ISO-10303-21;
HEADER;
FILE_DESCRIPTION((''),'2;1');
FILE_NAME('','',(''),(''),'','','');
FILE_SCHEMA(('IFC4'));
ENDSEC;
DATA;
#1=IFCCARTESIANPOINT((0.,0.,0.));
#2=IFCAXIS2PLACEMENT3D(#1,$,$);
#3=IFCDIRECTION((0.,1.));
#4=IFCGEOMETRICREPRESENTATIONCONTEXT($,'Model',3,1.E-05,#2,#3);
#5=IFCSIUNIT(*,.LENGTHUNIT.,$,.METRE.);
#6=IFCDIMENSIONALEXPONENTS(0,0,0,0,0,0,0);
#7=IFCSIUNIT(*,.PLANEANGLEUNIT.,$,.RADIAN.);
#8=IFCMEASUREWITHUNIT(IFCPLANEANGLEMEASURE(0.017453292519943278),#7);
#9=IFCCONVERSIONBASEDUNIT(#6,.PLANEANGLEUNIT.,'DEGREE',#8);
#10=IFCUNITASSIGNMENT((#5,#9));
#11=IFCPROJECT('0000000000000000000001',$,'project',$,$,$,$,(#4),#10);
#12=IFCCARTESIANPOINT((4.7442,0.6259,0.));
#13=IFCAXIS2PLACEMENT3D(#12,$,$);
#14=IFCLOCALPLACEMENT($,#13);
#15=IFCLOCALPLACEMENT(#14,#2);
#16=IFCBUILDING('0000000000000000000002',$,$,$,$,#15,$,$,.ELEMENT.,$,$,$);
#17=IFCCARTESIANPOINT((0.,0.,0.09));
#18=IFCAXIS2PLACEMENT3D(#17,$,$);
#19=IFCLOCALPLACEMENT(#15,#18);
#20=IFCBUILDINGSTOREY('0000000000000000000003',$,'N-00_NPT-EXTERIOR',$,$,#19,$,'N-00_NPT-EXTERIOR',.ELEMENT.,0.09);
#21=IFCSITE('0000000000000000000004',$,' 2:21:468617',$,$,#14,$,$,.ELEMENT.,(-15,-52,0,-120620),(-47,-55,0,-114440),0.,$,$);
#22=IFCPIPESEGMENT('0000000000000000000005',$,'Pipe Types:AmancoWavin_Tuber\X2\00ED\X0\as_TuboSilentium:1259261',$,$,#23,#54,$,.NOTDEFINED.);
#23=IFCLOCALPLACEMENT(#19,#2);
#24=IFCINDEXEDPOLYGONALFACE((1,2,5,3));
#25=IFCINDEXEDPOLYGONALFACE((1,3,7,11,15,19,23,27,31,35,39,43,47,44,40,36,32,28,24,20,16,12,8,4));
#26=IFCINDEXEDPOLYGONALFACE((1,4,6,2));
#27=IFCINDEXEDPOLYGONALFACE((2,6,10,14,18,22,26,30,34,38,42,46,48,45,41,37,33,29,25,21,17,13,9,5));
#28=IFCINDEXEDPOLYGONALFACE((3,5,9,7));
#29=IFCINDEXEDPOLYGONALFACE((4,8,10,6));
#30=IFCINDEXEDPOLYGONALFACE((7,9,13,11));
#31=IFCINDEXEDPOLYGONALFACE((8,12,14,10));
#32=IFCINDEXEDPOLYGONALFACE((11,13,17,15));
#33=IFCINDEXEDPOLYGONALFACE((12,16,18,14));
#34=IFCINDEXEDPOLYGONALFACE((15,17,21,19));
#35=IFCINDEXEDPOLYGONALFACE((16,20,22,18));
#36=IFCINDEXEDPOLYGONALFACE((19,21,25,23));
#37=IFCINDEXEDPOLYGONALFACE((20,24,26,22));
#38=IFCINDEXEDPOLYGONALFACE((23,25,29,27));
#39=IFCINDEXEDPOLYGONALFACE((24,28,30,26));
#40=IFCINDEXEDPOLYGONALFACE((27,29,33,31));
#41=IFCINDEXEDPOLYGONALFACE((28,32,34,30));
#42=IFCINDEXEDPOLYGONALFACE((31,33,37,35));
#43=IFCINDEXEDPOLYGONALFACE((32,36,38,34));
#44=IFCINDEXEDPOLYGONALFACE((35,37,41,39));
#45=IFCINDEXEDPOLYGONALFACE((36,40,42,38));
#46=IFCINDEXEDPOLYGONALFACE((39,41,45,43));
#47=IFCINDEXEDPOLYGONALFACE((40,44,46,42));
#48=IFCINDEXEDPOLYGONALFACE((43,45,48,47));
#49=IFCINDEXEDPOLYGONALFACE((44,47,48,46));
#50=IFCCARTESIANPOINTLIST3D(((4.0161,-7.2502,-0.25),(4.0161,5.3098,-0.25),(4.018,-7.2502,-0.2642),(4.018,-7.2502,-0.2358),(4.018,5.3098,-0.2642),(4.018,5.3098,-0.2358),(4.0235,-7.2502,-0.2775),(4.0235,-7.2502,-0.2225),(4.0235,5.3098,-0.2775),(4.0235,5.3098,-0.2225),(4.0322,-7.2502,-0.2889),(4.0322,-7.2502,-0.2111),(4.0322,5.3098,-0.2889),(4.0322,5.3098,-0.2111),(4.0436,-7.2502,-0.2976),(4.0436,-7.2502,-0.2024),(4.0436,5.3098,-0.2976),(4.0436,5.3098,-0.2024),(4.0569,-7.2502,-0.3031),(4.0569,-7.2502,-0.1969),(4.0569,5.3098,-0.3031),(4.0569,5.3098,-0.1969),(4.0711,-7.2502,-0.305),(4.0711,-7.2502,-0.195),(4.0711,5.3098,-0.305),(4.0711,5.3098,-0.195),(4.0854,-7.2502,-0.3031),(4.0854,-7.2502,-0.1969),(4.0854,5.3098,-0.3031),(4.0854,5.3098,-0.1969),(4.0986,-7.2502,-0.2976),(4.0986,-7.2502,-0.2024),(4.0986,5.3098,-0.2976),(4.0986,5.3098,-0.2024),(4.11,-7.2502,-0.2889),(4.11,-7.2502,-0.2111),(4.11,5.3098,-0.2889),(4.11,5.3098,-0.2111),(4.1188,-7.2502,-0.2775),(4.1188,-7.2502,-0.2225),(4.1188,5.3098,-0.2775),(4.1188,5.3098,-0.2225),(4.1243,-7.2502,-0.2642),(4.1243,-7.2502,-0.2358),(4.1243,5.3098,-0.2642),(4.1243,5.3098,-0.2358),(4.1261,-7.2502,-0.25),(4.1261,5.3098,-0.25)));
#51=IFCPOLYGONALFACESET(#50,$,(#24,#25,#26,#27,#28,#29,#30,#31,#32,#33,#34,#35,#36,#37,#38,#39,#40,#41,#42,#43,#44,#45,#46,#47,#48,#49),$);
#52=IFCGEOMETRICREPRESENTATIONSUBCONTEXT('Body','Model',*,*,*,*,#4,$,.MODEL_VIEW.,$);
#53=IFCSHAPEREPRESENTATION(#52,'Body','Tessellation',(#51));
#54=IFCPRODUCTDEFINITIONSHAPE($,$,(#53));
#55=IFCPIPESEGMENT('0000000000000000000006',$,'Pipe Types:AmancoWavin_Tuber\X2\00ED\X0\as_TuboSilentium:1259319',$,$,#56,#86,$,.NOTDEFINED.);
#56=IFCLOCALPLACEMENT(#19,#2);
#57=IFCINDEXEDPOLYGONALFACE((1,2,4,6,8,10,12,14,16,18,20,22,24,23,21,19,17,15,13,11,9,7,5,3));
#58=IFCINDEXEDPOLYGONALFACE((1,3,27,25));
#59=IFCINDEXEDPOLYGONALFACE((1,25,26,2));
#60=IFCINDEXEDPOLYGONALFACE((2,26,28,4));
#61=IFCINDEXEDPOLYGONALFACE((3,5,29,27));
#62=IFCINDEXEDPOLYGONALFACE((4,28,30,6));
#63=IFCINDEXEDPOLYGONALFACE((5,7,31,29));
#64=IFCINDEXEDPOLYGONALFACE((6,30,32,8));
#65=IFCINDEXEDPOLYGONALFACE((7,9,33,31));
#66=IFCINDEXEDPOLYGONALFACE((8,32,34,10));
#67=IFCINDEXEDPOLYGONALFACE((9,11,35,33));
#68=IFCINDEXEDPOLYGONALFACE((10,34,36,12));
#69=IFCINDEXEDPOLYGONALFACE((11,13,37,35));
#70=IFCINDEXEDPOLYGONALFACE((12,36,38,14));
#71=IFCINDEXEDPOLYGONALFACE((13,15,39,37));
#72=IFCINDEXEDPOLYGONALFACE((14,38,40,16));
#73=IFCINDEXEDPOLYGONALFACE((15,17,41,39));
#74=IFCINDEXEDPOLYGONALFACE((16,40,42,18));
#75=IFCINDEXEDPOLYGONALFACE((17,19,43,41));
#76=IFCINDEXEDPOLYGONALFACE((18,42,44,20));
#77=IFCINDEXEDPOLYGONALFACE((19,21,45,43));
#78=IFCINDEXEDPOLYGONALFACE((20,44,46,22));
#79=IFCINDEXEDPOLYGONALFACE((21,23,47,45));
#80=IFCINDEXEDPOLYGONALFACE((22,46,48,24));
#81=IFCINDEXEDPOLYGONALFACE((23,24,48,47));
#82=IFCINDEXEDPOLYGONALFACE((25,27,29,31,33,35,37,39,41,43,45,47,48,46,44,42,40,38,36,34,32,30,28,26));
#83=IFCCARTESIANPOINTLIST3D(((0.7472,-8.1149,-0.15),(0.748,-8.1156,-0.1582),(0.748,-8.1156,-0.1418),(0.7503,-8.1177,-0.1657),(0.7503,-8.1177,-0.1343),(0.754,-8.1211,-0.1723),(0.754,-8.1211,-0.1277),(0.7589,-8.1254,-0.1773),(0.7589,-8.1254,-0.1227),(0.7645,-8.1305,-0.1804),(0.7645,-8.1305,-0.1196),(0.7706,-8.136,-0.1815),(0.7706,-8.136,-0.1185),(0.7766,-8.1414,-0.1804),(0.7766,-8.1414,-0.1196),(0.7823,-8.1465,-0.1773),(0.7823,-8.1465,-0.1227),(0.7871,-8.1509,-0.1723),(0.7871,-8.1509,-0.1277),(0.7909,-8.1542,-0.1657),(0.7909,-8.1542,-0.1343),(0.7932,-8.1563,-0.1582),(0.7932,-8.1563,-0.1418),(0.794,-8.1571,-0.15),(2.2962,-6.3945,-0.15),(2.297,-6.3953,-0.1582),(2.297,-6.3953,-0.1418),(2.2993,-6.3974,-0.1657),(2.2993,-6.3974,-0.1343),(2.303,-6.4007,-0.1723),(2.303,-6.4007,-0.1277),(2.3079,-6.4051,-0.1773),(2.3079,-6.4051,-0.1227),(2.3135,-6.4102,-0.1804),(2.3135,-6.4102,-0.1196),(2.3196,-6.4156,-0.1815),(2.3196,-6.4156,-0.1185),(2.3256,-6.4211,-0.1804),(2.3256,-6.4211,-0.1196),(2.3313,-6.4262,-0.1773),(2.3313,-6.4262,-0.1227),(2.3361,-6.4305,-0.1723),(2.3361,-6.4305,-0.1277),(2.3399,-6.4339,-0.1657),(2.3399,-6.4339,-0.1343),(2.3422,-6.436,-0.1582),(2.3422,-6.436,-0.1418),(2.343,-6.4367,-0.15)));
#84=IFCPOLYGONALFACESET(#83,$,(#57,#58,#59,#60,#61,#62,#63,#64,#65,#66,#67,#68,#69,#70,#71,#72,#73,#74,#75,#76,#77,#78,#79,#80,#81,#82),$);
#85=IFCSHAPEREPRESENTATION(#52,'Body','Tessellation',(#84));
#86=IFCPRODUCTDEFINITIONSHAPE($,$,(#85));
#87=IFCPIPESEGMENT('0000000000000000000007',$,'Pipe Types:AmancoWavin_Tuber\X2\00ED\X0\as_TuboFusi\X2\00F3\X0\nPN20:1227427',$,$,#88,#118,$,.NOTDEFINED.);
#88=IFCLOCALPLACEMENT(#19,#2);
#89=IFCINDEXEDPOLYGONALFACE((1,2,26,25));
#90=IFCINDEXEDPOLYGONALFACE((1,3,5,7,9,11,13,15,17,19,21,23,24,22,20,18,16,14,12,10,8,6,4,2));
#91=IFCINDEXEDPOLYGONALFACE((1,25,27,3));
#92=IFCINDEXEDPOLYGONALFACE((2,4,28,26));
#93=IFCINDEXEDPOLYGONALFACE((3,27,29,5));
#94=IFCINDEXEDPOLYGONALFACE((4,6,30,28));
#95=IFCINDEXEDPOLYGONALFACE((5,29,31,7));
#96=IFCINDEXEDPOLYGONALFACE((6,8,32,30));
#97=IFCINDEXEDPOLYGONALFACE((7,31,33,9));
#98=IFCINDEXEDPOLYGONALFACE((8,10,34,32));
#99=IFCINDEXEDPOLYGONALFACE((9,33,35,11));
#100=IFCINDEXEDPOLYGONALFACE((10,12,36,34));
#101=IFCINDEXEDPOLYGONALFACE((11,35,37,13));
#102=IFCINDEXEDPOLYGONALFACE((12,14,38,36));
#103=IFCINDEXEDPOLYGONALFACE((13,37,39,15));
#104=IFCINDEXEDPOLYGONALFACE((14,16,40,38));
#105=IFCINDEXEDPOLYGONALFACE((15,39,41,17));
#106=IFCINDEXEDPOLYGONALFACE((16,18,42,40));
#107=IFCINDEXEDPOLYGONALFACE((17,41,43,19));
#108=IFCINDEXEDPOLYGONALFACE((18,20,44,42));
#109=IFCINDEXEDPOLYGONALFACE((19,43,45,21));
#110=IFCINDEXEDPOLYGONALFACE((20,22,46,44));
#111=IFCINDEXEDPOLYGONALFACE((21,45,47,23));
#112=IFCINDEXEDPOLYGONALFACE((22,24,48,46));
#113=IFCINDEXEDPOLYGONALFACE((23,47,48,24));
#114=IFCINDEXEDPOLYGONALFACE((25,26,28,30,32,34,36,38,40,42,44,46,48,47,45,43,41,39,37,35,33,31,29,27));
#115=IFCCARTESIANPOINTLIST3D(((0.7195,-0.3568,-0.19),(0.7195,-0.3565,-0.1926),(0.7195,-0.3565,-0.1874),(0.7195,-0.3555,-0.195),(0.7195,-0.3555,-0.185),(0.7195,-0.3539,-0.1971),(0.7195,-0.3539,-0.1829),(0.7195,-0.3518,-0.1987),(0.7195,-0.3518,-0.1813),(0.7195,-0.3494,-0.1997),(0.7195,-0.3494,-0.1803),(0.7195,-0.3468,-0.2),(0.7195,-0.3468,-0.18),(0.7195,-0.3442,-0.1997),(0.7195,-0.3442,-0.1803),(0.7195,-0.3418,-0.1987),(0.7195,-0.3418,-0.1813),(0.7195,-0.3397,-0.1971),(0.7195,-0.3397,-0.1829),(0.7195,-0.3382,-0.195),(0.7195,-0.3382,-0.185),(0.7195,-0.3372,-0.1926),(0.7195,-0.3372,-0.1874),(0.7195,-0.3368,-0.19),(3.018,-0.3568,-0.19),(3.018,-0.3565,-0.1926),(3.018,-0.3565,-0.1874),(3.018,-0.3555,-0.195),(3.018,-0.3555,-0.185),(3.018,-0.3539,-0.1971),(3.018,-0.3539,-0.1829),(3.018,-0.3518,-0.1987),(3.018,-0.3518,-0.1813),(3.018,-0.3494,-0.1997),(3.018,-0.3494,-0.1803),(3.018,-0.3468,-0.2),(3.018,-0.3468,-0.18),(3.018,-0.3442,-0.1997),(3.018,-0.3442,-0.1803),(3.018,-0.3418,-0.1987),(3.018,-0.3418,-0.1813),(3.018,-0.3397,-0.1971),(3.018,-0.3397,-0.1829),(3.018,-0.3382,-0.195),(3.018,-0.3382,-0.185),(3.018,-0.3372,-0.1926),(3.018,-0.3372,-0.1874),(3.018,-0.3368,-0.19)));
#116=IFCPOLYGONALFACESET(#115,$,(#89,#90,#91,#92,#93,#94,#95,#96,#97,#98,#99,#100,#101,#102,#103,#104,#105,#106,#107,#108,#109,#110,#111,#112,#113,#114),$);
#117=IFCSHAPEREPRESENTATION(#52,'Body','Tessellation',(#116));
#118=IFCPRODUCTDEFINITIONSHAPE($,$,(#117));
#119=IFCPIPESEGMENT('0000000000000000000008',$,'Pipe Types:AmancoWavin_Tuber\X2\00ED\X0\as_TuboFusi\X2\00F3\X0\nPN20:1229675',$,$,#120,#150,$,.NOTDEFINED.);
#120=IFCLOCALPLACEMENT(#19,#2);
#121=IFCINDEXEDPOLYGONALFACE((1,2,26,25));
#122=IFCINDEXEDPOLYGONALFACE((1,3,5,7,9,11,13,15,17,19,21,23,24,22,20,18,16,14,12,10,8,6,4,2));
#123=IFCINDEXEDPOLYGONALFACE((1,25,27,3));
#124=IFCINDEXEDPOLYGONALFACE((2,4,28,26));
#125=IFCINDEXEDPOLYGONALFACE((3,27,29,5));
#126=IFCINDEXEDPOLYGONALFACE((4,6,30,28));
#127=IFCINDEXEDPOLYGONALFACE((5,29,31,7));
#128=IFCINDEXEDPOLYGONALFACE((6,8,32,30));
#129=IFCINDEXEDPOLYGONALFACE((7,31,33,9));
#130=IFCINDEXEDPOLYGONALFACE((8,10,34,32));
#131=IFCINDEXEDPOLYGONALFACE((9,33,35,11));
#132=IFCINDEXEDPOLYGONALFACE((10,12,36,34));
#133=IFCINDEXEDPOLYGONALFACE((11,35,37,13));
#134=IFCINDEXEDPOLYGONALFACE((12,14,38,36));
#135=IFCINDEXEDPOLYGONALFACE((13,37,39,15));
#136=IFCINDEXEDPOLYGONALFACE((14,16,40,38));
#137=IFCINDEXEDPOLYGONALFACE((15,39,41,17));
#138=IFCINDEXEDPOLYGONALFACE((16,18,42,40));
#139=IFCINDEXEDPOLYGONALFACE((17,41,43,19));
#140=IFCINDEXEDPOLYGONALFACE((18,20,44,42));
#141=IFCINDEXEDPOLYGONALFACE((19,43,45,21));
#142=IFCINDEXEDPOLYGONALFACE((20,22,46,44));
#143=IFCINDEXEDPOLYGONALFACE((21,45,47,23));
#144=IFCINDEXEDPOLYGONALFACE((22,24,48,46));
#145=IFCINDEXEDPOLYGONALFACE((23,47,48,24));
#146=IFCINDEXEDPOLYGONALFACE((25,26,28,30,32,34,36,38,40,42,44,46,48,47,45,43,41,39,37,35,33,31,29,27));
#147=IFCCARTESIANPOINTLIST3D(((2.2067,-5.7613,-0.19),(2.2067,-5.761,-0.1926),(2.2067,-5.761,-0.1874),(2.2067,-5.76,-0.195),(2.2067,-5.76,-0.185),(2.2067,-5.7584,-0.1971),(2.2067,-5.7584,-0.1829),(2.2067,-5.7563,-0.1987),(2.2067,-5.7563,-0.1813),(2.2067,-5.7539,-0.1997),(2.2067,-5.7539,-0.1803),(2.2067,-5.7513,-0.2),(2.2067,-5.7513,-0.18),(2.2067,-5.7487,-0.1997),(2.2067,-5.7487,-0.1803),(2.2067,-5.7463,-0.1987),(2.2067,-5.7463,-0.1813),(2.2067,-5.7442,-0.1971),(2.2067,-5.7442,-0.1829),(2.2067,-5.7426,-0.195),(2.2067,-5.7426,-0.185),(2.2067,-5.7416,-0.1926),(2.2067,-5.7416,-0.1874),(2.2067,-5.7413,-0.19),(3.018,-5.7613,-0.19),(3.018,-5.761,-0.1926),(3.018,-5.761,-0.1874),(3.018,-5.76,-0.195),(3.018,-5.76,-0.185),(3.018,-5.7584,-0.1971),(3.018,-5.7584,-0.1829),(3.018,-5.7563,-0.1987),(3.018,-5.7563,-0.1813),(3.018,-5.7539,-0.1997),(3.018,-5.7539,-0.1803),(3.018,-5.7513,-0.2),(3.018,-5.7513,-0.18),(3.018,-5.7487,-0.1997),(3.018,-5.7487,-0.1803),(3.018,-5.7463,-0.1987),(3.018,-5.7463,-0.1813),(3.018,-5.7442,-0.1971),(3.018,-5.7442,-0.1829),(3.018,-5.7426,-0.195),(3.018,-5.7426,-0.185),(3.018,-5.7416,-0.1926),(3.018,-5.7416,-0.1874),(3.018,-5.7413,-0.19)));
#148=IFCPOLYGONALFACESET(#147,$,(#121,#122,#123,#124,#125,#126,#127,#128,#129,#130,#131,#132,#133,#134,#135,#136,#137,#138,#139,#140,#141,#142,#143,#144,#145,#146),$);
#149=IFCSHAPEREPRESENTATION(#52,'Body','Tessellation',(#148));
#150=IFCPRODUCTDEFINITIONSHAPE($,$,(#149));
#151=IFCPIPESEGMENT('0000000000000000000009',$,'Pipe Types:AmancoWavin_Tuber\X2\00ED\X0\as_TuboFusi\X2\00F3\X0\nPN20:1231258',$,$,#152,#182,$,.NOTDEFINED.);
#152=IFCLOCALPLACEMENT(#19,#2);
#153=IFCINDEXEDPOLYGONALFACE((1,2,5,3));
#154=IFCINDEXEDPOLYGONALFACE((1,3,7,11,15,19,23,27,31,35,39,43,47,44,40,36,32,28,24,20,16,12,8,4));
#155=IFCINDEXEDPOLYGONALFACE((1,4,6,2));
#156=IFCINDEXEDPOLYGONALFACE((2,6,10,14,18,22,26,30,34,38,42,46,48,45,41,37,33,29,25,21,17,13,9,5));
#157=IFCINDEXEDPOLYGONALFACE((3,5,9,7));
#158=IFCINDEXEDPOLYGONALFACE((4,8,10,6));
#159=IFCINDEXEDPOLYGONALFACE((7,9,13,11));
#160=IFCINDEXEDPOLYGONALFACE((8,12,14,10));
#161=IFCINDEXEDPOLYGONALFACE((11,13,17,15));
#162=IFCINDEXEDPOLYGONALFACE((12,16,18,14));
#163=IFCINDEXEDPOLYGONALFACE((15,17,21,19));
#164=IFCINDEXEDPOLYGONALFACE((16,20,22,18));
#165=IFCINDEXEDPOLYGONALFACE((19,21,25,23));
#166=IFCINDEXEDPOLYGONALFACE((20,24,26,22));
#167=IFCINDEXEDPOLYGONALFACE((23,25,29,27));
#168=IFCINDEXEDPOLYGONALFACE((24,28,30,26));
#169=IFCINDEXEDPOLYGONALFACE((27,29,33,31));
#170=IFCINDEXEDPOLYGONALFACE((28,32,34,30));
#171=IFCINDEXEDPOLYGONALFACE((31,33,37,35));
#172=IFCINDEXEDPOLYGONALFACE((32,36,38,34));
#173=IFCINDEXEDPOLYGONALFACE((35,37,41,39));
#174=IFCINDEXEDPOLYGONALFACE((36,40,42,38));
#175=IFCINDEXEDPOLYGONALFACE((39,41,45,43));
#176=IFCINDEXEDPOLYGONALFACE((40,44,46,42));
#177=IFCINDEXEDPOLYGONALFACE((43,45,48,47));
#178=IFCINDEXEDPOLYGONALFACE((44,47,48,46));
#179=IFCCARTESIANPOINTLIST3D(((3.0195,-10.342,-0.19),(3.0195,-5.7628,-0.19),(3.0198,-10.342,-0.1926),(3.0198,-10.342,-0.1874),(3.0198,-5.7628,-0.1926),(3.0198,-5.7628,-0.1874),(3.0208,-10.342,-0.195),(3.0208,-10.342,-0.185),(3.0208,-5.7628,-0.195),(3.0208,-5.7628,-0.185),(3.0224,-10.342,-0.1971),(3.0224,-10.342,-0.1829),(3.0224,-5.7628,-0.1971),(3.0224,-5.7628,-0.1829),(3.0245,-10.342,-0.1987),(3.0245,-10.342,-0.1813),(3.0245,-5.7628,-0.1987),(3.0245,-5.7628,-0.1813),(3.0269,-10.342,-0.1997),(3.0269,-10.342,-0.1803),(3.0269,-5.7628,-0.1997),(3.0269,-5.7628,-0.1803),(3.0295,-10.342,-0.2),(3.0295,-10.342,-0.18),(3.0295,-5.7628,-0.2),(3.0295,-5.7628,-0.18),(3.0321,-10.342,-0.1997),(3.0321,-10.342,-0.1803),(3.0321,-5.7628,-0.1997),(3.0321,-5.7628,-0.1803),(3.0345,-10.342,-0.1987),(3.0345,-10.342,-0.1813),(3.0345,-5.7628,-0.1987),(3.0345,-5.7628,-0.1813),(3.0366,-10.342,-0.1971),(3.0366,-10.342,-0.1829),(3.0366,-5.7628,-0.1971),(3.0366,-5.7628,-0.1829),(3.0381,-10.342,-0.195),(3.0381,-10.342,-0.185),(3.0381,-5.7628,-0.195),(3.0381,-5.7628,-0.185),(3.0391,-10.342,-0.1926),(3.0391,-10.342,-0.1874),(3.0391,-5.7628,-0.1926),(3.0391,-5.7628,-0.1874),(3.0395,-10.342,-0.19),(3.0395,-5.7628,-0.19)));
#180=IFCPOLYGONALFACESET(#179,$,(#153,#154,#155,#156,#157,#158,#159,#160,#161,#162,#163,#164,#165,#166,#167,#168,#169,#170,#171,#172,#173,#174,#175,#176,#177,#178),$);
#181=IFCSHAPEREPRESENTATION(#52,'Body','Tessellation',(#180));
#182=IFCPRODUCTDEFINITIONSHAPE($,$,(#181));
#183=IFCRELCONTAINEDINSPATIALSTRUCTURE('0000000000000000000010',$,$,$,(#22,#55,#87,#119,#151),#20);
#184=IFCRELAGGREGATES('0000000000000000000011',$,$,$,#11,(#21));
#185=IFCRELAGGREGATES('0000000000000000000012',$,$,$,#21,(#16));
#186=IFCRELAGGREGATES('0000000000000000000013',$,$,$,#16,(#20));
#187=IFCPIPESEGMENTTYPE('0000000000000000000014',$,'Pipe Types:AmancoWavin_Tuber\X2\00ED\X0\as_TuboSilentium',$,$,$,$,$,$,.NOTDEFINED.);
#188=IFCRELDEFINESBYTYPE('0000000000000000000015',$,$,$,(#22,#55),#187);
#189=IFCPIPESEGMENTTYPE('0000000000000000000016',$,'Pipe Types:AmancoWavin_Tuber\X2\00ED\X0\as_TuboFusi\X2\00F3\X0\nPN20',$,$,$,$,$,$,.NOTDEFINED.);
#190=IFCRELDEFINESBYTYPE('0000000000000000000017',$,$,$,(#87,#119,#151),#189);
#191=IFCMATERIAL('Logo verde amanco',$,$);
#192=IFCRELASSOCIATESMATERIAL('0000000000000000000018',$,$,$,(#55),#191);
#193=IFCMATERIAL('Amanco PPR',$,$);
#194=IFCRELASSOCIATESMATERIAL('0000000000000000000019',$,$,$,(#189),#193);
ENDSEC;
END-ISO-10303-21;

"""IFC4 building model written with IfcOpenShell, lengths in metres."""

from ifc_helpers import new_model, entity, si_unit, converted_unit, direction, frame, origin, place, context, subcontext, project, spatial, arc, indexed_curve, outline, extrude, material, type_object, element, save


model = new_model("IFC4")

# Units and contexts
model_context = context("Model", 3, precision=1e-05, world=origin(), true_north=direction((0.0, 1.0)))
body_context = subcontext(model_context, "Body", "Model", "MODEL_VIEW")
ifc_project = project(units=[si_unit("LENGTHUNIT", "METRE"), converted_unit("PLANEANGLEUNIT", "DEGREE", entity("IfcPlaneAngleMeasure", 0.017453292519943278), si_unit("PLANEANGLEUNIT", "RADIAN"), dimensions=[0, 0, 0, 0, 0, 0, 0])], contexts=[model_context])

# Site, building, storey
site_placement = place(None, frame((4.7442, 0.6259, 0.0)))
site = spatial("IfcSite", under=ifc_project, at=site_placement, Name=" 2:21:468617", CompositionType="ELEMENT", RefLatitude=(-15, -52, 0, -120620), RefLongitude=(-47, -55, 0, -114440), RefElevation=0.0)
building_placement = place(site_placement, origin())
building = spatial("IfcBuilding", under=site, at=building_placement, CompositionType="ELEMENT")
storey_placement = place(building_placement, frame((0.0, 0.0, 0.09)))
storey = spatial("IfcBuildingStorey", under=building, at=storey_placement, Name="N-00_NPT-EXTERIOR", LongName="N-00_NPT-EXTERIOR", CompositionType="ELEMENT", Elevation=0.09)

# Pipe segments
pipe_segment_type_1 = type_object("IfcPipeSegmentType", Name="Pipe Types:AmancoWavin_Tuberías_TuboSilentium", PredefinedType="NOTDEFINED")
pipe_segment_1_placement = place(storey_placement, origin())
element("IfcPipeSegment", 1, at=pipe_segment_1_placement, inside=storey, type_object=pipe_segment_type_1, Name="Pipe Types:AmancoWavin_Tuberías_TuboSilentium:1259261", PredefinedType="NOTDEFINED", context=body_context, shape_type="SweptSolid", body=[
    extrude(outline(indexed_curve([(0.055, 0.0), (0.0389, 0.0389), (0.0, 0.055), (-0.0389, 0.0389), (-0.055, 0.0), (-0.0389, -0.0389), (0.0, -0.055), (0.0389, -0.0389)], segments=[arc(1, 2, 3), arc(3, 4, 5), arc(5, 6, 7), arc(7, 8, 1)], self_intersect=False)), frame((4.0711, -7.2502, -0.25), z_axis=(0.0, 1.0, 0.0), x_axis=(-1.0, 0.0, 0.0)), (0.0, 0.0, 1.0), 12.56),
])
ifc_material_1 = material(Name="Logo verde amanco")
pipe_segment_2_placement = place(storey_placement, origin())
element("IfcPipeSegment", 2, at=pipe_segment_2_placement, inside=storey, type_object=pipe_segment_type_1, material=ifc_material_1, Name="Pipe Types:AmancoWavin_Tuberías_TuboSilentium:1259319", PredefinedType="NOTDEFINED", context=body_context, shape_type="SweptSolid", body=[
    extrude(outline(indexed_curve([(0.0315, 0.0), (0.0223, 0.0223), (0.0, 0.0315), (-0.0223, 0.0223), (-0.0315, 0.0), (-0.0223, -0.0223), (0.0, -0.0315), (0.0223, -0.0223)], segments=[arc(1, 2, 3), arc(3, 4, 5), arc(5, 6, 7), arc(7, 8, 1)], self_intersect=False)), frame((0.7706, -8.136, -0.15), z_axis=(0.669131, 0.743145, 0.0), x_axis=(0.743145, -0.669131, 0.0)), (0.0, 0.0, 1.0), 2.315),
])
ifc_material_2 = material(Name="Amanco PPR")
pipe_segment_type_2 = type_object("IfcPipeSegmentType", Name="Pipe Types:AmancoWavin_Tuberías_TuboFusiónPN20", PredefinedType="NOTDEFINED", material=ifc_material_2)
pipe_segment_3_placement = place(storey_placement, origin())
element("IfcPipeSegment", 3, at=pipe_segment_3_placement, inside=storey, type_object=pipe_segment_type_2, Name="Pipe Types:AmancoWavin_Tuberías_TuboFusiónPN20:1227427", PredefinedType="NOTDEFINED", context=body_context, shape_type="SweptSolid", body=[
    extrude(outline(indexed_curve([(0.01, 0.0), (0.0071, 0.0071), (0.0, 0.01), (-0.0071, 0.0071), (-0.01, 0.0), (-0.0071, -0.0071), (0.0, -0.01), (0.0071, -0.0071)], segments=[arc(1, 2, 3), arc(3, 4, 5), arc(5, 6, 7), arc(7, 8, 1)], self_intersect=False)), frame((0.7195, -0.3468, -0.19), z_axis=(1.0, 0.0, 0.0), x_axis=(0.0, -1.0, 0.0)), (0.0, 0.0, 1.0), 2.2985),
])
pipe_segment_4_placement = place(storey_placement, origin())
element("IfcPipeSegment", 4, at=pipe_segment_4_placement, inside=storey, type_object=pipe_segment_type_2, Name="Pipe Types:AmancoWavin_Tuberías_TuboFusiónPN20:1229675", PredefinedType="NOTDEFINED", context=body_context, shape_type="SweptSolid", body=[
    extrude(outline(indexed_curve([(0.01, 0.0), (0.0071, 0.0071), (0.0, 0.01), (-0.0071, 0.0071), (-0.01, 0.0), (-0.0071, -0.0071), (0.0, -0.01), (0.0071, -0.0071)], segments=[arc(1, 2, 3), arc(3, 4, 5), arc(5, 6, 7), arc(7, 8, 1)], self_intersect=False)), frame((2.2067, -5.7513, -0.19), z_axis=(1.0, 0.0, 0.0), x_axis=(0.0, -1.0, 0.0)), (0.0, 0.0, 1.0), 0.8113),
])
pipe_segment_5_placement = place(storey_placement, origin())
element("IfcPipeSegment", 5, at=pipe_segment_5_placement, inside=storey, type_object=pipe_segment_type_2, Name="Pipe Types:AmancoWavin_Tuberías_TuboFusiónPN20:1231258", PredefinedType="NOTDEFINED", context=body_context, shape_type="SweptSolid", body=[
    extrude(outline(indexed_curve([(0.01, 0.0), (0.0071, 0.0071), (0.0, 0.01), (-0.0071, 0.0071), (-0.01, 0.0), (-0.0071, -0.0071), (0.0, -0.01), (0.0071, -0.0071)], segments=[arc(1, 2, 3), arc(3, 4, 5), arc(5, 6, 7), arc(7, 8, 1)], self_intersect=False)), frame((3.0295, -10.342, -0.19), z_axis=(0.0, 1.0, 0.0), x_axis=(-1.0, 0.0, 0.0)), (0.0, 0.0, 1.0), 4.5792),
])

save(model, "model.ifc")
